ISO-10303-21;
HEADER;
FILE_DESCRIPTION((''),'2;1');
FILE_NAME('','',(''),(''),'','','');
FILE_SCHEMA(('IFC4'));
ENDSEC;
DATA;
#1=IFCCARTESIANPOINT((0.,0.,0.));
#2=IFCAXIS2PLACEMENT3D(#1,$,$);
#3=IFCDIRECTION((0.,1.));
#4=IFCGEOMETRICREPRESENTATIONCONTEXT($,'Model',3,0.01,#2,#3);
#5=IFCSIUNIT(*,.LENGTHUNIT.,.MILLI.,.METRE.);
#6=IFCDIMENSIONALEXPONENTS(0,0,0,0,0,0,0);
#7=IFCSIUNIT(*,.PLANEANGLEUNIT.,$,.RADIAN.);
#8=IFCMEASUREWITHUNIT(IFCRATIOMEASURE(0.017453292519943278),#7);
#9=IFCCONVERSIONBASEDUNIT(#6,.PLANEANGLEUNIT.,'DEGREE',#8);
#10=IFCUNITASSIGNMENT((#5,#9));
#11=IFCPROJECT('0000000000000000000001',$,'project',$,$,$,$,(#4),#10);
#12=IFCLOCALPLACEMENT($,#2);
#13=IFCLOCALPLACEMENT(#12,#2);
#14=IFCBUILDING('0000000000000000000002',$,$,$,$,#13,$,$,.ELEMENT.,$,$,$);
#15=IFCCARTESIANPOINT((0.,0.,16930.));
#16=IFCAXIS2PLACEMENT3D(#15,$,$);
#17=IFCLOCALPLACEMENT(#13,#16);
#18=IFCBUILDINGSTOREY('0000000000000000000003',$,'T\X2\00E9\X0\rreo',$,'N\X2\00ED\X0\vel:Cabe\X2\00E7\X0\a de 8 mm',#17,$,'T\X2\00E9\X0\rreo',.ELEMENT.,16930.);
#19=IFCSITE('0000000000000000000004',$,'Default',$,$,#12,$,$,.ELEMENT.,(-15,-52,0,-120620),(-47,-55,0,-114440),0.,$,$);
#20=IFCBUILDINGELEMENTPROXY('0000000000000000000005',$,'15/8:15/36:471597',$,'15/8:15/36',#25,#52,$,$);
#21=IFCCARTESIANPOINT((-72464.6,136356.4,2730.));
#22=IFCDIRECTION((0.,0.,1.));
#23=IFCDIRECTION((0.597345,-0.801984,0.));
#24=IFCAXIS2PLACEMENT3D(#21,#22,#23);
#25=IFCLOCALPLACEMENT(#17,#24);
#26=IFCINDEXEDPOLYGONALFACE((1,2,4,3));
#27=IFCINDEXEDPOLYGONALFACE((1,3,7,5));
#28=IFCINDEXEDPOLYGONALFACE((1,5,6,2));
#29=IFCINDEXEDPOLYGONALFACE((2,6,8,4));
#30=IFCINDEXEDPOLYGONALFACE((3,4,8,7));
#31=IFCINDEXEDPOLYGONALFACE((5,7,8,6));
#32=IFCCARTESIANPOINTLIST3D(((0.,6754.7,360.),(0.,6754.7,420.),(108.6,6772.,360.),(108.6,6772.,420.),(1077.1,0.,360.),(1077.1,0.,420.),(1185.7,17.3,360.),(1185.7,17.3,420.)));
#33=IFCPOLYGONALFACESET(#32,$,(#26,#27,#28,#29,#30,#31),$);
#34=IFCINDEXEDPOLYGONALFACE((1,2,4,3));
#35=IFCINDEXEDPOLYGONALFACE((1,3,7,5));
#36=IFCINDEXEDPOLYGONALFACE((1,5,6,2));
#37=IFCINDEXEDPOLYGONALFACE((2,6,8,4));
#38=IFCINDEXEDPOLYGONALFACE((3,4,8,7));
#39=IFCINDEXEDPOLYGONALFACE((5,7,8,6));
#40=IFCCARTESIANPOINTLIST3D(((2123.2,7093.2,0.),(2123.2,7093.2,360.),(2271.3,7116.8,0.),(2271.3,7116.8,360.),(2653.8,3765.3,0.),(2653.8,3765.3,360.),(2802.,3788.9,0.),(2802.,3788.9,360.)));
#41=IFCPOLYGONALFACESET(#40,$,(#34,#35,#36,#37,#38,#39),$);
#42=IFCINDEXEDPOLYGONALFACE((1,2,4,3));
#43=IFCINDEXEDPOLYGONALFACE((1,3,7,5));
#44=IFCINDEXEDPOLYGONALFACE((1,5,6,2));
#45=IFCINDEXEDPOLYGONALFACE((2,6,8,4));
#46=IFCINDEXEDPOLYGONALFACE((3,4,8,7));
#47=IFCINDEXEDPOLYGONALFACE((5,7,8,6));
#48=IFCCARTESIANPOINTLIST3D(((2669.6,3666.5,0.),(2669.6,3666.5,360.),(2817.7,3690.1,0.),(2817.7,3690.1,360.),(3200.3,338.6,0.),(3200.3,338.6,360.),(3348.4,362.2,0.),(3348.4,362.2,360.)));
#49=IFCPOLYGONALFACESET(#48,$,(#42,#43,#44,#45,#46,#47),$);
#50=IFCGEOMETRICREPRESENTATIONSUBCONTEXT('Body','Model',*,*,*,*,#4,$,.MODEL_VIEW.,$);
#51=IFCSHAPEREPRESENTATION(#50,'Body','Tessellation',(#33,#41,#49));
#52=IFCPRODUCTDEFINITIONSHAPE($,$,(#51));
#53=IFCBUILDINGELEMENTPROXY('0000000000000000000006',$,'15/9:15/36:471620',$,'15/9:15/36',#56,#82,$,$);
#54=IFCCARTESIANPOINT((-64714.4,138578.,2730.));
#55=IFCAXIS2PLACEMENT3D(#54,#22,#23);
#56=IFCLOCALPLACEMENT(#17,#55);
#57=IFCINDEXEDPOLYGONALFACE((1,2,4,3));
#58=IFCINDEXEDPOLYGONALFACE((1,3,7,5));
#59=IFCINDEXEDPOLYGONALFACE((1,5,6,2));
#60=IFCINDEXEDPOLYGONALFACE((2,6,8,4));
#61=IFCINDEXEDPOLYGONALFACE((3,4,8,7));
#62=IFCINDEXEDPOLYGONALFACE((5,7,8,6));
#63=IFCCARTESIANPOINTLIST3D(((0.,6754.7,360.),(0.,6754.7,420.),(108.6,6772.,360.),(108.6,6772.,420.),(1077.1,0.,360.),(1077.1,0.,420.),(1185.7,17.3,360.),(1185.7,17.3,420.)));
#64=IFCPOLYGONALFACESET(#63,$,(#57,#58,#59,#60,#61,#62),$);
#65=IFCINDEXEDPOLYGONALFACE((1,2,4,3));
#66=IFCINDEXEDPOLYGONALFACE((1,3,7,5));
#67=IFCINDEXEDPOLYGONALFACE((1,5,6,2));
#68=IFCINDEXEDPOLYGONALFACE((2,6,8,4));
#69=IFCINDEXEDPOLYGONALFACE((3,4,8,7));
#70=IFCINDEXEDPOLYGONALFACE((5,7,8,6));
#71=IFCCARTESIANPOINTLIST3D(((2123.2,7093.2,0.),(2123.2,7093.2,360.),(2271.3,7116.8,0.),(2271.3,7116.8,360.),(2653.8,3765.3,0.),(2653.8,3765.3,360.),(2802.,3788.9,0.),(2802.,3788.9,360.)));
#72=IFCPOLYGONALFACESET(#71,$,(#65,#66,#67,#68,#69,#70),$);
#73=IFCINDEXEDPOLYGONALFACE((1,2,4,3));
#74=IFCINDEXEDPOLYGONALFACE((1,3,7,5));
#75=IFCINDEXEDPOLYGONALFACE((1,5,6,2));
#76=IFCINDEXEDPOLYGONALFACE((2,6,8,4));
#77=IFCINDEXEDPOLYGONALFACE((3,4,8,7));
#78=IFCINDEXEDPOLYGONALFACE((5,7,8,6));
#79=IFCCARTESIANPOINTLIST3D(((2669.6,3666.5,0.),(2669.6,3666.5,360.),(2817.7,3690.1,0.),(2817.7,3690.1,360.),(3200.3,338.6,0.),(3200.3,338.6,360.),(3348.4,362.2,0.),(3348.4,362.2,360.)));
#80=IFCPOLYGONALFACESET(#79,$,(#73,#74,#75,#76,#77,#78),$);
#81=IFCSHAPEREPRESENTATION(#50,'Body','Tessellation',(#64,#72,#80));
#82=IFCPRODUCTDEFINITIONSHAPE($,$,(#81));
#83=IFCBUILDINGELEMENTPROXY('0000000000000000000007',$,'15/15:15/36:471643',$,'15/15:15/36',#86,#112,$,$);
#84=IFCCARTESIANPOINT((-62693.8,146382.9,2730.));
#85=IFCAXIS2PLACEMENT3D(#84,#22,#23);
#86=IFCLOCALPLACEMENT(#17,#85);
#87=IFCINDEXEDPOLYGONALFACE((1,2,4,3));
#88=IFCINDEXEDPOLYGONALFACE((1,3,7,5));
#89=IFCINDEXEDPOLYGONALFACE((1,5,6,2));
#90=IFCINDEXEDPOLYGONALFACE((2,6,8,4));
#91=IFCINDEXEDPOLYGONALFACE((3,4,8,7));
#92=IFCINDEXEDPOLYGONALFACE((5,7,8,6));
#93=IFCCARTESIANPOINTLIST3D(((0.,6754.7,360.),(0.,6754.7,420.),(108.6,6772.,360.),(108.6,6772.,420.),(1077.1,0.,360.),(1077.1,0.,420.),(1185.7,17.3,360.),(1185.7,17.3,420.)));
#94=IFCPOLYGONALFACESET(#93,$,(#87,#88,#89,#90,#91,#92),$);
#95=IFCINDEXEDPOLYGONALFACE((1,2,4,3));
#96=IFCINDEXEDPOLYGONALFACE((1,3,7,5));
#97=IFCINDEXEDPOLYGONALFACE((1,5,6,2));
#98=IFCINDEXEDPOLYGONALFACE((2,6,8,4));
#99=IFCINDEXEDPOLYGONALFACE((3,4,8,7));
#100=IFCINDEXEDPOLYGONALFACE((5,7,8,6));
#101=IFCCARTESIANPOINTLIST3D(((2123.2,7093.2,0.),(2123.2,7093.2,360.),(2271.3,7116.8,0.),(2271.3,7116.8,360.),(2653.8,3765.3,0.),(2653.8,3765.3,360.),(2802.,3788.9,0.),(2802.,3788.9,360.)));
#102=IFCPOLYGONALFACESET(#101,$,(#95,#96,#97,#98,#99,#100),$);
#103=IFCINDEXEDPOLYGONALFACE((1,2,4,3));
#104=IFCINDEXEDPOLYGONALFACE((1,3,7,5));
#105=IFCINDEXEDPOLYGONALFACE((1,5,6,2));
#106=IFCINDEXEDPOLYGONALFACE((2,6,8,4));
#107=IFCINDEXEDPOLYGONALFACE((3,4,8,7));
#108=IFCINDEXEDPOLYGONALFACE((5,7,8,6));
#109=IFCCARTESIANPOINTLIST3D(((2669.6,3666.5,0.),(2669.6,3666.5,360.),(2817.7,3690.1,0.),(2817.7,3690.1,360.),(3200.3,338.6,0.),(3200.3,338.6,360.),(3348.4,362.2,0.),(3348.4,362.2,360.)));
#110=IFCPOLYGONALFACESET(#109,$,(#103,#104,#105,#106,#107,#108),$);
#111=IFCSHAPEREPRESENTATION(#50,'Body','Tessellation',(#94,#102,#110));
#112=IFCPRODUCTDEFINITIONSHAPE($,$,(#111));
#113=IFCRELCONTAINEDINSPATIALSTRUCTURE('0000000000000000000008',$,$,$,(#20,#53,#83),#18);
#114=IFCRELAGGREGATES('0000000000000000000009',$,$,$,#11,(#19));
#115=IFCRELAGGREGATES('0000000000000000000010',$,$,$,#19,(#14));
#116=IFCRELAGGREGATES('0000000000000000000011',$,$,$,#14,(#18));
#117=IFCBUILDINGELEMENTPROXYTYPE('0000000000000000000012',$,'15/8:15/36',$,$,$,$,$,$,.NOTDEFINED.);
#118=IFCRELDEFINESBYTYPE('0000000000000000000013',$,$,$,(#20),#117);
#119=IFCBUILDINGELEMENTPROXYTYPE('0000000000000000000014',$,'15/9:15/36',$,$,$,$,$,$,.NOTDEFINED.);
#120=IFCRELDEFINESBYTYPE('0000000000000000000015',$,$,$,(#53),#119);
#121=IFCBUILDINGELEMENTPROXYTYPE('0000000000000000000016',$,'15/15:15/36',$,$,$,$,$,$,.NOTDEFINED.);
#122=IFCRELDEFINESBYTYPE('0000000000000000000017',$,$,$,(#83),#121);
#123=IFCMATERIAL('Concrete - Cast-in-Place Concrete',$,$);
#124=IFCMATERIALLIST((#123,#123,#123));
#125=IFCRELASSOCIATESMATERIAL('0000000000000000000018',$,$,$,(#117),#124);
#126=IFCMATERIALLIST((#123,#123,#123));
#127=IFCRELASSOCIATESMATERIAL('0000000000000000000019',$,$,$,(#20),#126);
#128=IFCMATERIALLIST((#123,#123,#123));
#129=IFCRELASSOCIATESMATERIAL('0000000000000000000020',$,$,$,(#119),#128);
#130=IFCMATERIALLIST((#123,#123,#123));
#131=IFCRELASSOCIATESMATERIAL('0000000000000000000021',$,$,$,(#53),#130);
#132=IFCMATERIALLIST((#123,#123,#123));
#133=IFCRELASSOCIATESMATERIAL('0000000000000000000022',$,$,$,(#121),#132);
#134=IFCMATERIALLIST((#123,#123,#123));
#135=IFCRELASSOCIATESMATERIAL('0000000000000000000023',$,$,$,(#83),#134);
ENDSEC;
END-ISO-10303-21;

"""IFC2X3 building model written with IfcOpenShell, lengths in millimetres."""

from ifc_helpers import new_model, entity, si_unit, converted_unit, direction, frame, frame_2d, origin, place, context, subcontext, project, spatial, rectangle, extrude, source, transform, mapped, material, material_list, type_object, type_shapes, element, save


model = new_model("IFC2X3")

# Units and contexts
model_context = context("Model", 3, precision=0.01, world=origin(), true_north=direction((0.0, 1.0)))
body_context = subcontext(model_context, "Body", "Model", "MODEL_VIEW")
ifc_project = project(units=[si_unit("LENGTHUNIT", "METRE", prefix="MILLI"), converted_unit("PLANEANGLEUNIT", "DEGREE", entity("IfcRatioMeasure", 0.017453292519943278), si_unit("PLANEANGLEUNIT", "RADIAN"), dimensions=[0, 0, 0, 0, 0, 0, 0])], contexts=[model_context])

# Site, building, storey
site_placement = place(None, origin())
site = spatial("IfcSite", under=ifc_project, at=site_placement, Name="Default", CompositionType="ELEMENT", RefLatitude=(-15, -52, 0, -120620), RefLongitude=(-47, -55, 0, -114440), RefElevation=0.0)
building_placement = place(site_placement, origin())
building = spatial("IfcBuilding", under=site, at=building_placement, CompositionType="ELEMENT")
storey_placement = place(building_placement, frame((0.0, 0.0, 16930.0)))
storey = spatial("IfcBuildingStorey", under=building, at=storey_placement, Name="Térreo", ObjectType="Nível:Cabeça de 8 mm", LongName="Térreo", CompositionType="ELEMENT", Elevation=16930.0)

# Building element proxies
ifc_material_1 = material(Name="Concrete - Cast-in-Place Concrete")
ifc_material_list_1 = material_list([ifc_material_1, ifc_material_1, ifc_material_1])
ifc_material_list_2 = material_list([ifc_material_1, ifc_material_1, ifc_material_1])
building_element_proxy_type_1 = type_object("IfcBuildingElementProxyType", Name="15/8:15/36", PredefinedType="NOTDEFINED", material=ifc_material_list_2)
shared_shape_1 = source(origin(), body_context, "Body", "SweptSolid", [
    extrude(rectangle(XDim=110.0, YDim=6840.0, at=frame_2d((0.0, 0.0), x_axis=(1.0, 0.0))), frame((592.9, 3386.0, 360.0), z_axis=(0.0, 0.0, 1.0), x_axis=(-0.987524, -0.157469, 0.0)), (0.0, 0.0, 1.0), 60.0),
    extrude(rectangle(XDim=3370.0, YDim=150.0, at=frame_2d((0.0, 0.0), x_axis=(1.0, 0.0))), frame((2462.6, 5441.1, 0.0), z_axis=(0.0, 0.0, 1.0), x_axis=(0.157469, -0.987524, 0.0)), (0.0, 0.0, 1.0), 360.0),
    extrude(rectangle(XDim=3370.0, YDim=150.0, at=frame_2d((0.0, 0.0), x_axis=(1.0, 0.0))), frame((3009.0, 2014.3, 0.0), z_axis=(0.0, 0.0, 1.0), x_axis=(0.157469, -0.987524, 0.0)), (0.0, 0.0, 1.0), 360.0),
])
type_shapes(building_element_proxy_type_1, [shared_shape_1])
proxy_1_placement = place(storey_placement, frame((-72464.6, 136356.4, 2730.0), z_axis=(0.0, 0.0, 1.0), x_axis=(0.597345, -0.801984, 0.0)))
element("IfcBuildingElementProxy", 1, at=proxy_1_placement, inside=storey, type_object=building_element_proxy_type_1, material=ifc_material_list_1, Name="15/8:15/36:471597", ObjectType="15/8:15/36", context=body_context, shape_type="MappedRepresentation", body=[
    mapped(shared_shape_1, transform((0.0, 0.0, 0.0), scale=1.0)),
])
ifc_material_list_3 = material_list([ifc_material_1, ifc_material_1, ifc_material_1])
ifc_material_list_4 = material_list([ifc_material_1, ifc_material_1, ifc_material_1])
building_element_proxy_type_2 = type_object("IfcBuildingElementProxyType", Name="15/9:15/36", PredefinedType="NOTDEFINED", material=ifc_material_list_4)
shared_shape_2 = source(origin(), body_context, "Body", "SweptSolid", [
    extrude(rectangle(XDim=110.0, YDim=6840.0, at=frame_2d((0.0, 0.0), x_axis=(1.0, 0.0))), frame((592.9, 3386.0, 360.0), z_axis=(0.0, 0.0, 1.0), x_axis=(-0.987524, -0.157469, 0.0)), (0.0, 0.0, 1.0), 60.0),
    extrude(rectangle(XDim=3370.0, YDim=150.0, at=frame_2d((0.0, 0.0), x_axis=(1.0, 0.0))), frame((2462.6, 5441.1, 0.0), z_axis=(0.0, 0.0, 1.0), x_axis=(0.157469, -0.987524, 0.0)), (0.0, 0.0, 1.0), 360.0),
    extrude(rectangle(XDim=3370.0, YDim=150.0, at=frame_2d((0.0, 0.0), x_axis=(1.0, 0.0))), frame((3009.0, 2014.3, 0.0), z_axis=(0.0, 0.0, 1.0), x_axis=(0.157469, -0.987524, 0.0)), (0.0, 0.0, 1.0), 360.0),
])
type_shapes(building_element_proxy_type_2, [shared_shape_2])
proxy_2_placement = place(storey_placement, frame((-64714.4, 138578.0, 2730.0), z_axis=(0.0, 0.0, 1.0), x_axis=(0.597345, -0.801984, 0.0)))
element("IfcBuildingElementProxy", 2, at=proxy_2_placement, inside=storey, type_object=building_element_proxy_type_2, material=ifc_material_list_3, Name="15/9:15/36:471620", ObjectType="15/9:15/36", context=body_context, shape_type="MappedRepresentation", body=[
    mapped(shared_shape_2, transform((0.0, 0.0, 0.0), scale=1.0)),
])
ifc_material_list_5 = material_list([ifc_material_1, ifc_material_1, ifc_material_1])
ifc_material_list_6 = material_list([ifc_material_1, ifc_material_1, ifc_material_1])
building_element_proxy_type_3 = type_object("IfcBuildingElementProxyType", Name="15/15:15/36", PredefinedType="NOTDEFINED", material=ifc_material_list_6)
shared_shape_3 = source(origin(), body_context, "Body", "SweptSolid", [
    extrude(rectangle(XDim=110.0, YDim=6840.0, at=frame_2d((0.0, 0.0), x_axis=(1.0, 0.0))), frame((592.9, 3386.0, 360.0), z_axis=(0.0, 0.0, 1.0), x_axis=(-0.987524, -0.157469, 0.0)), (0.0, 0.0, 1.0), 60.0),
    extrude(rectangle(XDim=3370.0, YDim=150.0, at=frame_2d((0.0, 0.0), x_axis=(1.0, 0.0))), frame((2462.6, 5441.1, 0.0), z_axis=(0.0, 0.0, 1.0), x_axis=(0.157469, -0.987524, 0.0)), (0.0, 0.0, 1.0), 360.0),
    extrude(rectangle(XDim=3370.0, YDim=150.0, at=frame_2d((0.0, 0.0), x_axis=(1.0, 0.0))), frame((3009.0, 2014.3, 0.0), z_axis=(0.0, 0.0, 1.0), x_axis=(0.157469, -0.987524, 0.0)), (0.0, 0.0, 1.0), 360.0),
])
type_shapes(building_element_proxy_type_3, [shared_shape_3])
proxy_3_placement = place(storey_placement, frame((-62693.8, 146382.9, 2730.0), z_axis=(0.0, 0.0, 1.0), x_axis=(0.597345, -0.801984, 0.0)))
element("IfcBuildingElementProxy", 3, at=proxy_3_placement, inside=storey, type_object=building_element_proxy_type_3, material=ifc_material_list_5, Name="15/15:15/36:471643", ObjectType="15/15:15/36", context=body_context, shape_type="MappedRepresentation", body=[
    mapped(shared_shape_3, transform((0.0, 0.0, 0.0), scale=1.0)),
])

save(model, "model.ifc")
